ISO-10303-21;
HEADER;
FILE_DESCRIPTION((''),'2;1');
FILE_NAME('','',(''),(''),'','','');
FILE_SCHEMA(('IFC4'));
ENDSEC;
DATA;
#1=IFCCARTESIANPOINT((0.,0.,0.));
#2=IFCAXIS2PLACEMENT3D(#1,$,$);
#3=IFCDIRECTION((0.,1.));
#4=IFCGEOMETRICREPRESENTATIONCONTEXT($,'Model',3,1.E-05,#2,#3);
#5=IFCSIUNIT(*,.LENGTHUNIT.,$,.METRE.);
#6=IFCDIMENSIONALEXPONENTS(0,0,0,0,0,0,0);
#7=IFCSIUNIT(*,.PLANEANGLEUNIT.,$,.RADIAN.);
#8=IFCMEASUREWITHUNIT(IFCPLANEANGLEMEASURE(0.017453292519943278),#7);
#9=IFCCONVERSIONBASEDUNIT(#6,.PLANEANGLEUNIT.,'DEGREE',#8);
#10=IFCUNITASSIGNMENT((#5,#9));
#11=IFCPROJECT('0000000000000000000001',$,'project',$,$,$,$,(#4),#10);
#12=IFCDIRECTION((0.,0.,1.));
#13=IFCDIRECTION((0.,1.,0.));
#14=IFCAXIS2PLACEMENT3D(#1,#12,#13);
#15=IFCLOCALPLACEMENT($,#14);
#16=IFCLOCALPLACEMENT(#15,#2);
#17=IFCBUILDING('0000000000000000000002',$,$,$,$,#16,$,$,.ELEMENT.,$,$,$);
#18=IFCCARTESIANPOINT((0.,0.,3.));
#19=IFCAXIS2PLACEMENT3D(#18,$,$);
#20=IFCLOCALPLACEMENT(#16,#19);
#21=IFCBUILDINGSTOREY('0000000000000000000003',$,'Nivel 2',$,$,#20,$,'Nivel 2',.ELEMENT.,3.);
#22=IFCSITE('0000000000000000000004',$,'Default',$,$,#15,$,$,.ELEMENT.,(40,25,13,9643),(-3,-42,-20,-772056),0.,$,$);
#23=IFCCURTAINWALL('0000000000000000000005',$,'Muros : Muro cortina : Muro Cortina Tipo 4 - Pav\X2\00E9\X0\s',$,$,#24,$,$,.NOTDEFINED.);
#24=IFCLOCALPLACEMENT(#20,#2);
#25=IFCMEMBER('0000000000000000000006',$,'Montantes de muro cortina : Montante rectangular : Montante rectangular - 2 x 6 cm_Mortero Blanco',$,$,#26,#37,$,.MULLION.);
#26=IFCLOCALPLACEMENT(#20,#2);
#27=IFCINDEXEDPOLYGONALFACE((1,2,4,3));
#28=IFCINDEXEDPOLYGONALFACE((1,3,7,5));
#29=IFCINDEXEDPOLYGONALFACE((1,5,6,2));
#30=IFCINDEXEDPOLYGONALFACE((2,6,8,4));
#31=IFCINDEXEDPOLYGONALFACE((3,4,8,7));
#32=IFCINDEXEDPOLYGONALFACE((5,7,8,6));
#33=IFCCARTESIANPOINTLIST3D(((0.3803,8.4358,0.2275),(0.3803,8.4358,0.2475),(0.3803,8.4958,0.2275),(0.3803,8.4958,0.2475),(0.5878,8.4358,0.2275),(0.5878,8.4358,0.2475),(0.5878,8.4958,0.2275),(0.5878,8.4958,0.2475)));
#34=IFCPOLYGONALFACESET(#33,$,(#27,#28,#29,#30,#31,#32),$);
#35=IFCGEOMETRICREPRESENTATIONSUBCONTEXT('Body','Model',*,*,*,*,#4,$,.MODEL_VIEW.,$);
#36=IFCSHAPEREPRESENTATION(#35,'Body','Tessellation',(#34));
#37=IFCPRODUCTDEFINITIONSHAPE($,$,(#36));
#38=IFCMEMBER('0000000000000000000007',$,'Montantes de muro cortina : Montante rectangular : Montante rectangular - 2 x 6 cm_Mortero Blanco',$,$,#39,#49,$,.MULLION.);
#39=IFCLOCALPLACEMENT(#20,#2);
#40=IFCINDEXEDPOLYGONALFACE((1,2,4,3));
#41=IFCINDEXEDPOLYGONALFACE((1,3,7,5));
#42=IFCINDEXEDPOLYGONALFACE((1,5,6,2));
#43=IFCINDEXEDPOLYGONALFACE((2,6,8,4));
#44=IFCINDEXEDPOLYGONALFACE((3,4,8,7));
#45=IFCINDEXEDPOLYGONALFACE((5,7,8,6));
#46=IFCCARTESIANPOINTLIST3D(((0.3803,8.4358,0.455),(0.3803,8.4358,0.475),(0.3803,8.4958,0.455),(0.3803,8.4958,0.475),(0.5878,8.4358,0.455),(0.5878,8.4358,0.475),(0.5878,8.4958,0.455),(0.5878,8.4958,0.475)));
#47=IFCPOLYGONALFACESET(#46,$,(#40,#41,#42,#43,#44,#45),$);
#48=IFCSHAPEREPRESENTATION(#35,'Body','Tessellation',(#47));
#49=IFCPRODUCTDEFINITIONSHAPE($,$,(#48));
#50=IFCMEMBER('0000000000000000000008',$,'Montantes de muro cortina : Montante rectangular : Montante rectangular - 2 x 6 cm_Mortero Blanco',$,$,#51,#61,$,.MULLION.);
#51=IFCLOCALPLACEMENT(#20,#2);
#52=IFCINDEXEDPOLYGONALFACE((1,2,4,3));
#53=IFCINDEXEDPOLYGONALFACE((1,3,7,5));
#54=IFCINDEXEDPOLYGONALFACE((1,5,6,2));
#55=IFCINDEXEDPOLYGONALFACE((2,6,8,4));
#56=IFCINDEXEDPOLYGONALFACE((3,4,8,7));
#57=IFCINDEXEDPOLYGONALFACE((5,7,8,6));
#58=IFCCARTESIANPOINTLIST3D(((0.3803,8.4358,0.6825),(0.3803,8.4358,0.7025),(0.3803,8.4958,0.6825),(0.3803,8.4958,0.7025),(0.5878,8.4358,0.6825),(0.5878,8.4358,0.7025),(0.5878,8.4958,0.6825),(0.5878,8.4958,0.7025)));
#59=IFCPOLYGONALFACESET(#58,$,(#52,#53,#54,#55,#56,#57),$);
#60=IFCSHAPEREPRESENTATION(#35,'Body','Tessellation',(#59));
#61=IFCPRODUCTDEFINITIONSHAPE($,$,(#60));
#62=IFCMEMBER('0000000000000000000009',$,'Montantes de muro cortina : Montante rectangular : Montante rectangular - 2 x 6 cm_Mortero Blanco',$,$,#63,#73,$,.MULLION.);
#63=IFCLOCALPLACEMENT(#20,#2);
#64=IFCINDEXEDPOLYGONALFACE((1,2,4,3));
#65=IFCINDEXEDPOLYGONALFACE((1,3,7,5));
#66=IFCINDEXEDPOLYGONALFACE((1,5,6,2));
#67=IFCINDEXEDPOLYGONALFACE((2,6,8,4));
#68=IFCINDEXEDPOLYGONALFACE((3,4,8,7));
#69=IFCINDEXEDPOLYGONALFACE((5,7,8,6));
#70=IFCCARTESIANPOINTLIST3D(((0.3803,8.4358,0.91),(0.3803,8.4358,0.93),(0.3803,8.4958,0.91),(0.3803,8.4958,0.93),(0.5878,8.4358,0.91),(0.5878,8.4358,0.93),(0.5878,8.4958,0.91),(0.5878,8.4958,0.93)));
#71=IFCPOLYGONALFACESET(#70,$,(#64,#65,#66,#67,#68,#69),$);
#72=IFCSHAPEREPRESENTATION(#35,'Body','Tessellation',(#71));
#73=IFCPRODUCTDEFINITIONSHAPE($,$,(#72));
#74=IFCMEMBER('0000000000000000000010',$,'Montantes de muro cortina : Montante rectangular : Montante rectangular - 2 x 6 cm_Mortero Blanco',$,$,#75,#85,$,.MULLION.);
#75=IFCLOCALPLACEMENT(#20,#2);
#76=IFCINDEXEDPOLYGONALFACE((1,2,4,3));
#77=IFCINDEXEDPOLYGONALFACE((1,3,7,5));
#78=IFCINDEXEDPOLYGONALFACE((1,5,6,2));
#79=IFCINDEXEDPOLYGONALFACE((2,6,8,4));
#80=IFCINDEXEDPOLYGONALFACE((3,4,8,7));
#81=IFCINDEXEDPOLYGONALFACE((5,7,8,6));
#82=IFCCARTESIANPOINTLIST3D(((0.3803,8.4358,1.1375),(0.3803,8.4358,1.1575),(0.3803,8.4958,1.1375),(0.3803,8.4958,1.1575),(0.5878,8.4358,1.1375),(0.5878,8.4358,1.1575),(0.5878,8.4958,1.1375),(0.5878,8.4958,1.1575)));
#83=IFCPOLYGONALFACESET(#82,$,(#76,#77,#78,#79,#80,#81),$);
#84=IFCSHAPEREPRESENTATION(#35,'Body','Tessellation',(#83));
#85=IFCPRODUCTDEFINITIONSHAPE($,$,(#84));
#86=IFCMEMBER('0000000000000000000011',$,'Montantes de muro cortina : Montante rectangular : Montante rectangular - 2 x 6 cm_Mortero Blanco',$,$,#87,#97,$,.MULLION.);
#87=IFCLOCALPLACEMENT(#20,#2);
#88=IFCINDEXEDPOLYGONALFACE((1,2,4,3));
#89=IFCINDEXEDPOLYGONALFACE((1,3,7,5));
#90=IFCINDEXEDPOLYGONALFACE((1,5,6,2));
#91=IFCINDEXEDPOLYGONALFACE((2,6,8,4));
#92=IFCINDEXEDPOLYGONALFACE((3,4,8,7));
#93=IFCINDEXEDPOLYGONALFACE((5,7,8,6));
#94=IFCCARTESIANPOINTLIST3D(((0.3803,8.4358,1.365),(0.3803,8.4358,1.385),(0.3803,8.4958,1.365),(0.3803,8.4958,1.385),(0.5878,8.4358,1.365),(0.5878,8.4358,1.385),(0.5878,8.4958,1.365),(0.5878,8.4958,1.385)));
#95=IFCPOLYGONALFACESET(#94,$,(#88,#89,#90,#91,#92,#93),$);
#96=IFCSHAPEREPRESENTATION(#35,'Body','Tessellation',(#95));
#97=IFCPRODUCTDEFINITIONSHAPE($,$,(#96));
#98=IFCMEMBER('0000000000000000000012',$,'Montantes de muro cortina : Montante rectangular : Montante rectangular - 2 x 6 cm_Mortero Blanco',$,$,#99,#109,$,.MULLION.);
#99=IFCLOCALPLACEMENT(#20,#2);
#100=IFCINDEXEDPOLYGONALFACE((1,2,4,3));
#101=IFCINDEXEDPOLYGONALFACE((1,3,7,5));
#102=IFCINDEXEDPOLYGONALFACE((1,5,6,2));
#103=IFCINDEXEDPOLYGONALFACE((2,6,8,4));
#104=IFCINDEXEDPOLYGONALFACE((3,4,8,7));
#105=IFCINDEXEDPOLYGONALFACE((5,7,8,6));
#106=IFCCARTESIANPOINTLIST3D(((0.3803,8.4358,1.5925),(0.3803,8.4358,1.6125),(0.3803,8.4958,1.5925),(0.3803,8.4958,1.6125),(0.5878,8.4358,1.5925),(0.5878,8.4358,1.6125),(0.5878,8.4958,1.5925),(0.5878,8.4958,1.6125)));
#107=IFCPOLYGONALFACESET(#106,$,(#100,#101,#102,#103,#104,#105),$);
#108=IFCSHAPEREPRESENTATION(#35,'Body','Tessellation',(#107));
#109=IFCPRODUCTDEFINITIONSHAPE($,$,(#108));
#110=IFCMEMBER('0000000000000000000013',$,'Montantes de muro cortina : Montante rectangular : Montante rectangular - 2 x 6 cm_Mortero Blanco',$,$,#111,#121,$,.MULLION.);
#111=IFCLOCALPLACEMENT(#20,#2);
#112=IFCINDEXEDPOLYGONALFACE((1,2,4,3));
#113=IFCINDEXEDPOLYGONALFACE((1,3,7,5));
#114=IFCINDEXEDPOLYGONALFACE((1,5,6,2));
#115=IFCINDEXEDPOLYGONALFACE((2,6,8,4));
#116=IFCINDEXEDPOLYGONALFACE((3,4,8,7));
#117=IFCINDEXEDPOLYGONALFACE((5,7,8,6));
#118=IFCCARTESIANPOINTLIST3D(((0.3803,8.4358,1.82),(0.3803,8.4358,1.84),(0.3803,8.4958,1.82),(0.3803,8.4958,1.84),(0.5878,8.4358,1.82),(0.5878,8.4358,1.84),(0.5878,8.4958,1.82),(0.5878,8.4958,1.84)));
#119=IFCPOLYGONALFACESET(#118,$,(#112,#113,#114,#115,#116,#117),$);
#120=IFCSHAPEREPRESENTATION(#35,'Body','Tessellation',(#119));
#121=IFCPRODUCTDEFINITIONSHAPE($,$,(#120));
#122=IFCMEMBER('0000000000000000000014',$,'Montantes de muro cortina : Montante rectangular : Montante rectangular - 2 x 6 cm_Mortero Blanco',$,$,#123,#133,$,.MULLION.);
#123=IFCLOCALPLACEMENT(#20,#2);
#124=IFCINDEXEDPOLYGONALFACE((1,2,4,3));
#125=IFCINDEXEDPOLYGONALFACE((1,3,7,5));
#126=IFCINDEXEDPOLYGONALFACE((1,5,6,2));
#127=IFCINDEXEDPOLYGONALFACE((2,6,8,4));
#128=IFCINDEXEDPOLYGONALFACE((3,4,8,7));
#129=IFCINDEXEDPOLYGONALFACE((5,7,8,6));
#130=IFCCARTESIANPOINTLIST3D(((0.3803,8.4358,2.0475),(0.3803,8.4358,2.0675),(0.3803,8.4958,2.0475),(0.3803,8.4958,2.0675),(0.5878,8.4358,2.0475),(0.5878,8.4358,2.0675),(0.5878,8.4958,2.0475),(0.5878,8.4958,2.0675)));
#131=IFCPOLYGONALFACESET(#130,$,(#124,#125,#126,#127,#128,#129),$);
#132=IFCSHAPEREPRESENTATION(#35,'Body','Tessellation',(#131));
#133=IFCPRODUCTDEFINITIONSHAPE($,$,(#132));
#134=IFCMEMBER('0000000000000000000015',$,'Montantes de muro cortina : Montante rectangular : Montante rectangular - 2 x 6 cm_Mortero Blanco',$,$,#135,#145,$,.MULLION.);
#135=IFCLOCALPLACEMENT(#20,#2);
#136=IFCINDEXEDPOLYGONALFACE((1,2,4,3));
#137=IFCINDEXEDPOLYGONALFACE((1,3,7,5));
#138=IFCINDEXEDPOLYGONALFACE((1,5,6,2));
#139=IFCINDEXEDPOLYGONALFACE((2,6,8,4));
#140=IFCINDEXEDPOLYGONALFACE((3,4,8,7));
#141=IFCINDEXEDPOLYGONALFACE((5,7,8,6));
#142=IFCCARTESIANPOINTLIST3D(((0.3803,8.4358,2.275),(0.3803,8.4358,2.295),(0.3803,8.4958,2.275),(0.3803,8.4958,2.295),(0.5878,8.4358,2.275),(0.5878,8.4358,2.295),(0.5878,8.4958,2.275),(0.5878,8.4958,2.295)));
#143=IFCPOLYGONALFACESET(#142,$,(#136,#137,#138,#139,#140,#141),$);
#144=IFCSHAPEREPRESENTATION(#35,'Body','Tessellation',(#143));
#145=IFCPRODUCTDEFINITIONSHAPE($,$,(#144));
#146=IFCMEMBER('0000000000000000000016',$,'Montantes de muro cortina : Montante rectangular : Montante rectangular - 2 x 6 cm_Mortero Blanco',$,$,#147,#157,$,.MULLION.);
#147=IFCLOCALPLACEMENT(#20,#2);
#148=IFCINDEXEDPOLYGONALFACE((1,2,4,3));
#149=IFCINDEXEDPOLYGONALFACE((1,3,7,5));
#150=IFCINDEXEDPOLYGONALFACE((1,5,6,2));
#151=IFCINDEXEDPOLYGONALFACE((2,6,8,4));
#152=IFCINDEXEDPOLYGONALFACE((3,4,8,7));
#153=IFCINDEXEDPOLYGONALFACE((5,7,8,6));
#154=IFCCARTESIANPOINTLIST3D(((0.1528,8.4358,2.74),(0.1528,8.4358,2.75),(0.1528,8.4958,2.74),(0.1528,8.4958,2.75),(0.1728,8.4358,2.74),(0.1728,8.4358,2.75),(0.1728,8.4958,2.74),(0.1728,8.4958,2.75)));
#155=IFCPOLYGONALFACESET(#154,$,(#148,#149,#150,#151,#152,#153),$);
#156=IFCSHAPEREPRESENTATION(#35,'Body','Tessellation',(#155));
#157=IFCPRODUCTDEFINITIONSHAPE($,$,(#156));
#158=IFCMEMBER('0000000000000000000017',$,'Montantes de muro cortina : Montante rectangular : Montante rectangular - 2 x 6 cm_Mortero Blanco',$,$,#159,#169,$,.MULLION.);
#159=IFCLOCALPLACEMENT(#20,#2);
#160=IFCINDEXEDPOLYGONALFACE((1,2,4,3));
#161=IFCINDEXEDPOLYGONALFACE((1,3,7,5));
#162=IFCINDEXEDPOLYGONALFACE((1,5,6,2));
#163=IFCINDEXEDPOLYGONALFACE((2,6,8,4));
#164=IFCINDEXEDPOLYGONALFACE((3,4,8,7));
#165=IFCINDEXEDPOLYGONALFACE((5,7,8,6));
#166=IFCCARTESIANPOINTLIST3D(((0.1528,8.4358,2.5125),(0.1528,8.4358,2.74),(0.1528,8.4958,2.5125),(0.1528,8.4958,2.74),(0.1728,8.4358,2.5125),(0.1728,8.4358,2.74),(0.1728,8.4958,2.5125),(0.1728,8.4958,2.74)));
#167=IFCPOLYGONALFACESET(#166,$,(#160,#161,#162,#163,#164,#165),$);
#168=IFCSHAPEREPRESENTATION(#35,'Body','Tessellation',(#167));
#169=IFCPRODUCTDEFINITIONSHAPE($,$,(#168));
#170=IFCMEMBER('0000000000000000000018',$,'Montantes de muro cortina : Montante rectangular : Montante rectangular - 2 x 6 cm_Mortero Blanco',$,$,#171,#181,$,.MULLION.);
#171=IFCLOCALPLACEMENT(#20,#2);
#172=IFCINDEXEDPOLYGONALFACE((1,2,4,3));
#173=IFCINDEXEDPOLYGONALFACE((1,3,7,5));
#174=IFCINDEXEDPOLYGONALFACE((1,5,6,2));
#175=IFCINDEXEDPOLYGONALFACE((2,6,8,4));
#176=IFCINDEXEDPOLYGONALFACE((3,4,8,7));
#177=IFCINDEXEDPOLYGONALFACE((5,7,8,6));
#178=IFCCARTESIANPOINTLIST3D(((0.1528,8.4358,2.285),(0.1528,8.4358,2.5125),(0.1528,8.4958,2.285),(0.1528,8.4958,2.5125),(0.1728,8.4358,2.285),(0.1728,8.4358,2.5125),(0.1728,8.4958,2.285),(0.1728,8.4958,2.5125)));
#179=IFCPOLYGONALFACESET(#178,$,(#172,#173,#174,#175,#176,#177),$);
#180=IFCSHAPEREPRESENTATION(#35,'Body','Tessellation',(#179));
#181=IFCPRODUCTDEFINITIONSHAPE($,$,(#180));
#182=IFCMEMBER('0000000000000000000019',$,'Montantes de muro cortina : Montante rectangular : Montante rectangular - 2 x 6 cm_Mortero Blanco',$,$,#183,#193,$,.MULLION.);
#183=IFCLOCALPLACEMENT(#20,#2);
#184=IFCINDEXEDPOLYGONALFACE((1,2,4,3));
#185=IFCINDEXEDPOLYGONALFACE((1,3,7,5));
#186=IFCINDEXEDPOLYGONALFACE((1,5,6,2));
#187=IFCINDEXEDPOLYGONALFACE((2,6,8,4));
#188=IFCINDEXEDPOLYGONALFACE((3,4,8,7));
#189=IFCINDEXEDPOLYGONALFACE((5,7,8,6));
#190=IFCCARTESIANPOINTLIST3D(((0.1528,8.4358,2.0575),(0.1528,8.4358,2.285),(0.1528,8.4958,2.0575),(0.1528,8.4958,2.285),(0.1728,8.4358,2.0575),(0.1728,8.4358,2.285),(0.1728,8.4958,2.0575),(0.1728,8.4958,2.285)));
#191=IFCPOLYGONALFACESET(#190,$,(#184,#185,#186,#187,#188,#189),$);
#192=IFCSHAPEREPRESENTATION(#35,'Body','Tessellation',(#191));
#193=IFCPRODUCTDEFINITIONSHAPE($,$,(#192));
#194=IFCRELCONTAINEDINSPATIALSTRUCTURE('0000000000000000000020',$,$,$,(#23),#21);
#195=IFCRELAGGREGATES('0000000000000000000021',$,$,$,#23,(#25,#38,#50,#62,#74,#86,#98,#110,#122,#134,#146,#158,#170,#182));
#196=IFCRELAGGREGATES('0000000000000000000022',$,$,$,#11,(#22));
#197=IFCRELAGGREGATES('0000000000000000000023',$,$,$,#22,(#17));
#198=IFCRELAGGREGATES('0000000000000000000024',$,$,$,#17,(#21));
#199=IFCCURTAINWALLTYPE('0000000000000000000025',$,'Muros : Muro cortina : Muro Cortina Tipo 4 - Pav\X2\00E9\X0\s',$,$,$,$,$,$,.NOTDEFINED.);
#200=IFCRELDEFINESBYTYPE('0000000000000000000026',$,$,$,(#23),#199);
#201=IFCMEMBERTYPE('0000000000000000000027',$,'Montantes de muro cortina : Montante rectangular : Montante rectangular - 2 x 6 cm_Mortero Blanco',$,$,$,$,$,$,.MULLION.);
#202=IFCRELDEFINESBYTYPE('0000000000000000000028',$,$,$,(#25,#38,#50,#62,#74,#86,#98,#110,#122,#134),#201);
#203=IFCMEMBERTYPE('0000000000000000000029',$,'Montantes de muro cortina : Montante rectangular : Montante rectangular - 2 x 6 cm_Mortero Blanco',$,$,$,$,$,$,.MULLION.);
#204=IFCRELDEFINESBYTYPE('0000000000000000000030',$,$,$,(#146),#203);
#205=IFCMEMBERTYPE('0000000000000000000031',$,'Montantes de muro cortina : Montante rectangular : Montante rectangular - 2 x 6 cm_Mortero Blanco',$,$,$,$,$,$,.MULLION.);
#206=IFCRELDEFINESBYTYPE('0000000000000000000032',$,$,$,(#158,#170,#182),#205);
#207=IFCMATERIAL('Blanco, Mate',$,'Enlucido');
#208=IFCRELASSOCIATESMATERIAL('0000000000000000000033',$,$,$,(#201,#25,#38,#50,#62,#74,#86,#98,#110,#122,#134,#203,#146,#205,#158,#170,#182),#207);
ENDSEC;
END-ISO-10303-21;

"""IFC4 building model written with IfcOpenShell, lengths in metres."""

from ifc_helpers import new_model, entity, si_unit, converted_unit, direction, frame, origin, place, context, subcontext, project, spatial, indexed_curve, outline, extrude, source, transform, mapped, material, type_object, type_shapes, element, aggregate, save


model = new_model("IFC4")

# Units and contexts
model_context = context("Model", 3, precision=1e-05, world=origin(), true_north=direction((0.0, 1.0)))
body_context = subcontext(model_context, "Body", "Model", "MODEL_VIEW")
ifc_project = project(units=[si_unit("LENGTHUNIT", "METRE"), converted_unit("PLANEANGLEUNIT", "DEGREE", entity("IfcPlaneAngleMeasure", 0.017453292519943278), si_unit("PLANEANGLEUNIT", "RADIAN"), dimensions=[0, 0, 0, 0, 0, 0, 0])], contexts=[model_context])

# Site, building, storey
site_placement = place(None, frame((0.0, 0.0, 0.0), z_axis=(0.0, 0.0, 1.0), x_axis=(0.0, 1.0, 0.0)))
site = spatial("IfcSite", under=ifc_project, at=site_placement, Name="Default", CompositionType="ELEMENT", RefLatitude=(40, 25, 13, 9643), RefLongitude=(-3, -42, -20, -772056), RefElevation=0.0)
building_placement = place(site_placement, origin())
building = spatial("IfcBuilding", under=site, at=building_placement, CompositionType="ELEMENT")
storey_placement = place(building_placement, frame((0.0, 0.0, 3.0)))
storey = spatial("IfcBuildingStorey", under=building, at=storey_placement, Name="Nivel 2", LongName="Nivel 2", CompositionType="ELEMENT", Elevation=3.0)

# Curtain wall, members
curtain_wall_type = type_object("IfcCurtainWallType", Name="Muros : Muro cortina : Muro Cortina Tipo 4 - Pavés", PredefinedType="NOTDEFINED")
curtain_wall_placement = place(storey_placement, frame((0.0, 0.0, -3.0)))
curtain_wall = element("IfcCurtainWall", 1, at=curtain_wall_placement, inside=storey, type_object=curtain_wall_type, Name="Muros : Muro cortina : Muro Cortina Tipo 4 - Pavés", PredefinedType="NOTDEFINED")
ifc_material_1 = material(Name="Blanco, Mate", Category="Enlucido")
member_type_1 = type_object("IfcMemberType", Name="Montantes de muro cortina : Montante rectangular : Montante rectangular - 2 x 6 cm_Mortero Blanco", PredefinedType="MULLION", material=ifc_material_1)
shared_shape_1 = source(origin(), body_context, "Body", "SweptSolid", [
    extrude(outline(indexed_curve([(-0.01, -0.03), (0.01, -0.03), (0.01, 0.03), (-0.01, 0.03), (-0.01, -0.03)], self_intersect=False)), frame((0.0, 0.0, -0.2075), z_axis=(0.0, 0.0, 1.0), x_axis=(-1.0, 0.0, 0.0)), (0.0, 0.0, 1.0), 0.2075),
])
type_shapes(member_type_1, [shared_shape_1])
member_1_placement = place(curtain_wall_placement, frame((0.3803, 8.4658, 3.2375), z_axis=(-1.0, 0.0, 0.0), x_axis=(0.0, 0.0, 1.0)))
member_1 = element("IfcMember", 2, at=member_1_placement, type_object=member_type_1, material=ifc_material_1, Name="Montantes de muro cortina : Montante rectangular : Montante rectangular - 2 x 6 cm_Mortero Blanco", PredefinedType="MULLION", context=body_context, shape_type="MappedRepresentation", body=[
    mapped(shared_shape_1, transform((0.0, 0.0, 0.0), scale=1.0)),
])
member_2_placement = place(curtain_wall_placement, frame((0.3803, 8.4658, 3.465), z_axis=(-1.0, 0.0, 0.0), x_axis=(0.0, 0.0, 1.0)))
member_2 = element("IfcMember", 3, at=member_2_placement, type_object=member_type_1, material=ifc_material_1, Name="Montantes de muro cortina : Montante rectangular : Montante rectangular - 2 x 6 cm_Mortero Blanco", PredefinedType="MULLION", context=body_context, shape_type="MappedRepresentation", body=[
    mapped(shared_shape_1, transform((0.0, 0.0, 0.0), scale=1.0)),
])
member_3_placement = place(curtain_wall_placement, frame((0.3803, 8.4658, 3.6925), z_axis=(-1.0, 0.0, 0.0), x_axis=(0.0, 0.0, 1.0)))
member_3 = element("IfcMember", 4, at=member_3_placement, type_object=member_type_1, material=ifc_material_1, Name="Montantes de muro cortina : Montante rectangular : Montante rectangular - 2 x 6 cm_Mortero Blanco", PredefinedType="MULLION", context=body_context, shape_type="MappedRepresentation", body=[
    mapped(shared_shape_1, transform((0.0, 0.0, 0.0), scale=1.0)),
])
member_4_placement = place(curtain_wall_placement, frame((0.3803, 8.4658, 3.92), z_axis=(-1.0, 0.0, 0.0), x_axis=(0.0, 0.0, 1.0)))
member_4 = element("IfcMember", 5, at=member_4_placement, type_object=member_type_1, material=ifc_material_1, Name="Montantes de muro cortina : Montante rectangular : Montante rectangular - 2 x 6 cm_Mortero Blanco", PredefinedType="MULLION", context=body_context, shape_type="MappedRepresentation", body=[
    mapped(shared_shape_1, transform((0.0, 0.0, 0.0), scale=1.0)),
])
member_5_placement = place(curtain_wall_placement, frame((0.3803, 8.4658, 4.1475), z_axis=(-1.0, 0.0, 0.0), x_axis=(0.0, 0.0, 1.0)))
member_5 = element("IfcMember", 6, at=member_5_placement, type_object=member_type_1, material=ifc_material_1, Name="Montantes de muro cortina : Montante rectangular : Montante rectangular - 2 x 6 cm_Mortero Blanco", PredefinedType="MULLION", context=body_context, shape_type="MappedRepresentation", body=[
    mapped(shared_shape_1, transform((0.0, 0.0, 0.0), scale=1.0)),
])
member_6_placement = place(curtain_wall_placement, frame((0.3803, 8.4658, 4.375), z_axis=(-1.0, 0.0, 0.0), x_axis=(0.0, 0.0, 1.0)))
member_6 = element("IfcMember", 7, at=member_6_placement, type_object=member_type_1, material=ifc_material_1, Name="Montantes de muro cortina : Montante rectangular : Montante rectangular - 2 x 6 cm_Mortero Blanco", PredefinedType="MULLION", context=body_context, shape_type="MappedRepresentation", body=[
    mapped(shared_shape_1, transform((0.0, 0.0, 0.0), scale=1.0)),
])
member_7_placement = place(curtain_wall_placement, frame((0.3803, 8.4658, 4.6025), z_axis=(-1.0, 0.0, 0.0), x_axis=(0.0, 0.0, 1.0)))
member_7 = element("IfcMember", 8, at=member_7_placement, type_object=member_type_1, material=ifc_material_1, Name="Montantes de muro cortina : Montante rectangular : Montante rectangular - 2 x 6 cm_Mortero Blanco", PredefinedType="MULLION", context=body_context, shape_type="MappedRepresentation", body=[
    mapped(shared_shape_1, transform((0.0, 0.0, 0.0), scale=1.0)),
])
member_8_placement = place(curtain_wall_placement, frame((0.3803, 8.4658, 4.83), z_axis=(-1.0, 0.0, 0.0), x_axis=(0.0, 0.0, 1.0)))
member_8 = element("IfcMember", 9, at=member_8_placement, type_object=member_type_1, material=ifc_material_1, Name="Montantes de muro cortina : Montante rectangular : Montante rectangular - 2 x 6 cm_Mortero Blanco", PredefinedType="MULLION", context=body_context, shape_type="MappedRepresentation", body=[
    mapped(shared_shape_1, transform((0.0, 0.0, 0.0), scale=1.0)),
])
member_9_placement = place(curtain_wall_placement, frame((0.3803, 8.4658, 5.0575), z_axis=(-1.0, 0.0, 0.0), x_axis=(0.0, 0.0, 1.0)))
member_9 = element("IfcMember", 10, at=member_9_placement, type_object=member_type_1, material=ifc_material_1, Name="Montantes de muro cortina : Montante rectangular : Montante rectangular - 2 x 6 cm_Mortero Blanco", PredefinedType="MULLION", context=body_context, shape_type="MappedRepresentation", body=[
    mapped(shared_shape_1, transform((0.0, 0.0, 0.0), scale=1.0)),
])
member_10_placement = place(curtain_wall_placement, frame((0.3803, 8.4658, 5.285), z_axis=(-1.0, 0.0, 0.0), x_axis=(0.0, 0.0, 1.0)))
member_10 = element("IfcMember", 11, at=member_10_placement, type_object=member_type_1, material=ifc_material_1, Name="Montantes de muro cortina : Montante rectangular : Montante rectangular - 2 x 6 cm_Mortero Blanco", PredefinedType="MULLION", context=body_context, shape_type="MappedRepresentation", body=[
    mapped(shared_shape_1, transform((0.0, 0.0, 0.0), scale=1.0)),
])
member_type_2 = type_object("IfcMemberType", Name="Montantes de muro cortina : Montante rectangular : Montante rectangular - 2 x 6 cm_Mortero Blanco", PredefinedType="MULLION", material=ifc_material_1)
shared_shape_2 = source(origin(), body_context, "Body", "SweptSolid", [
    extrude(outline(indexed_curve([(-0.01, -0.03), (0.01, -0.03), (0.01, 0.03), (-0.01, 0.03), (-0.01, -0.03)], self_intersect=False)), frame((-0.01, 0.0, -0.01), z_axis=(0.0, 0.0, 1.0), x_axis=(-1.0, 0.0, 0.0)), (0.0, 0.0, 1.0), 0.01),
])
type_shapes(member_type_2, [shared_shape_2])
member_11_placement = place(curtain_wall_placement, frame((0.1528, 8.4658, 5.74), z_axis=(0.0, 0.0, -1.0), x_axis=(-1.0, 0.0, 0.0)))
member_11 = element("IfcMember", 12, at=member_11_placement, type_object=member_type_2, material=ifc_material_1, Name="Montantes de muro cortina : Montante rectangular : Montante rectangular - 2 x 6 cm_Mortero Blanco", PredefinedType="MULLION", context=body_context, shape_type="MappedRepresentation", body=[
    mapped(shared_shape_2, transform((0.0, 0.0, 0.0), scale=1.0)),
])
member_type_3 = type_object("IfcMemberType", Name="Montantes de muro cortina : Montante rectangular : Montante rectangular - 2 x 6 cm_Mortero Blanco", PredefinedType="MULLION", material=ifc_material_1)
shared_shape_3 = source(origin(), body_context, "Body", "SweptSolid", [
    extrude(outline(indexed_curve([(-0.01, -0.03), (0.01, -0.03), (0.01, 0.03), (-0.01, 0.03), (-0.01, -0.03)], self_intersect=False)), frame((-0.01, 0.0, -0.2275), z_axis=(0.0, 0.0, 1.0), x_axis=(-1.0, 0.0, 0.0)), (0.0, 0.0, 1.0), 0.2275),
])
type_shapes(member_type_3, [shared_shape_3])
member_12_placement = place(curtain_wall_placement, frame((0.1528, 8.4658, 5.5125), z_axis=(0.0, 0.0, -1.0), x_axis=(-1.0, 0.0, 0.0)))
member_12 = element("IfcMember", 13, at=member_12_placement, type_object=member_type_3, material=ifc_material_1, Name="Montantes de muro cortina : Montante rectangular : Montante rectangular - 2 x 6 cm_Mortero Blanco", PredefinedType="MULLION", context=body_context, shape_type="MappedRepresentation", body=[
    mapped(shared_shape_3, transform((0.0, 0.0, 0.0), scale=1.0)),
])
member_13_placement = place(curtain_wall_placement, frame((0.1528, 8.4658, 5.285), z_axis=(0.0, 0.0, -1.0), x_axis=(-1.0, 0.0, 0.0)))
member_13 = element("IfcMember", 14, at=member_13_placement, type_object=member_type_3, material=ifc_material_1, Name="Montantes de muro cortina : Montante rectangular : Montante rectangular - 2 x 6 cm_Mortero Blanco", PredefinedType="MULLION", context=body_context, shape_type="MappedRepresentation", body=[
    mapped(shared_shape_3, transform((0.0, 0.0, 0.0), scale=1.0)),
])
member_14_placement = place(curtain_wall_placement, frame((0.1528, 8.4658, 5.0575), z_axis=(0.0, 0.0, -1.0), x_axis=(-1.0, 0.0, 0.0)))
member_14 = element("IfcMember", 15, at=member_14_placement, type_object=member_type_3, material=ifc_material_1, Name="Montantes de muro cortina : Montante rectangular : Montante rectangular - 2 x 6 cm_Mortero Blanco", PredefinedType="MULLION", context=body_context, shape_type="MappedRepresentation", body=[
    mapped(shared_shape_3, transform((0.0, 0.0, 0.0), scale=1.0)),
])
aggregate(curtain_wall, [member_1, member_2, member_3, member_4, member_5, member_6, member_7, member_8, member_9, member_10, member_11, member_12, member_13, member_14])

save(model, "model.ifc")
